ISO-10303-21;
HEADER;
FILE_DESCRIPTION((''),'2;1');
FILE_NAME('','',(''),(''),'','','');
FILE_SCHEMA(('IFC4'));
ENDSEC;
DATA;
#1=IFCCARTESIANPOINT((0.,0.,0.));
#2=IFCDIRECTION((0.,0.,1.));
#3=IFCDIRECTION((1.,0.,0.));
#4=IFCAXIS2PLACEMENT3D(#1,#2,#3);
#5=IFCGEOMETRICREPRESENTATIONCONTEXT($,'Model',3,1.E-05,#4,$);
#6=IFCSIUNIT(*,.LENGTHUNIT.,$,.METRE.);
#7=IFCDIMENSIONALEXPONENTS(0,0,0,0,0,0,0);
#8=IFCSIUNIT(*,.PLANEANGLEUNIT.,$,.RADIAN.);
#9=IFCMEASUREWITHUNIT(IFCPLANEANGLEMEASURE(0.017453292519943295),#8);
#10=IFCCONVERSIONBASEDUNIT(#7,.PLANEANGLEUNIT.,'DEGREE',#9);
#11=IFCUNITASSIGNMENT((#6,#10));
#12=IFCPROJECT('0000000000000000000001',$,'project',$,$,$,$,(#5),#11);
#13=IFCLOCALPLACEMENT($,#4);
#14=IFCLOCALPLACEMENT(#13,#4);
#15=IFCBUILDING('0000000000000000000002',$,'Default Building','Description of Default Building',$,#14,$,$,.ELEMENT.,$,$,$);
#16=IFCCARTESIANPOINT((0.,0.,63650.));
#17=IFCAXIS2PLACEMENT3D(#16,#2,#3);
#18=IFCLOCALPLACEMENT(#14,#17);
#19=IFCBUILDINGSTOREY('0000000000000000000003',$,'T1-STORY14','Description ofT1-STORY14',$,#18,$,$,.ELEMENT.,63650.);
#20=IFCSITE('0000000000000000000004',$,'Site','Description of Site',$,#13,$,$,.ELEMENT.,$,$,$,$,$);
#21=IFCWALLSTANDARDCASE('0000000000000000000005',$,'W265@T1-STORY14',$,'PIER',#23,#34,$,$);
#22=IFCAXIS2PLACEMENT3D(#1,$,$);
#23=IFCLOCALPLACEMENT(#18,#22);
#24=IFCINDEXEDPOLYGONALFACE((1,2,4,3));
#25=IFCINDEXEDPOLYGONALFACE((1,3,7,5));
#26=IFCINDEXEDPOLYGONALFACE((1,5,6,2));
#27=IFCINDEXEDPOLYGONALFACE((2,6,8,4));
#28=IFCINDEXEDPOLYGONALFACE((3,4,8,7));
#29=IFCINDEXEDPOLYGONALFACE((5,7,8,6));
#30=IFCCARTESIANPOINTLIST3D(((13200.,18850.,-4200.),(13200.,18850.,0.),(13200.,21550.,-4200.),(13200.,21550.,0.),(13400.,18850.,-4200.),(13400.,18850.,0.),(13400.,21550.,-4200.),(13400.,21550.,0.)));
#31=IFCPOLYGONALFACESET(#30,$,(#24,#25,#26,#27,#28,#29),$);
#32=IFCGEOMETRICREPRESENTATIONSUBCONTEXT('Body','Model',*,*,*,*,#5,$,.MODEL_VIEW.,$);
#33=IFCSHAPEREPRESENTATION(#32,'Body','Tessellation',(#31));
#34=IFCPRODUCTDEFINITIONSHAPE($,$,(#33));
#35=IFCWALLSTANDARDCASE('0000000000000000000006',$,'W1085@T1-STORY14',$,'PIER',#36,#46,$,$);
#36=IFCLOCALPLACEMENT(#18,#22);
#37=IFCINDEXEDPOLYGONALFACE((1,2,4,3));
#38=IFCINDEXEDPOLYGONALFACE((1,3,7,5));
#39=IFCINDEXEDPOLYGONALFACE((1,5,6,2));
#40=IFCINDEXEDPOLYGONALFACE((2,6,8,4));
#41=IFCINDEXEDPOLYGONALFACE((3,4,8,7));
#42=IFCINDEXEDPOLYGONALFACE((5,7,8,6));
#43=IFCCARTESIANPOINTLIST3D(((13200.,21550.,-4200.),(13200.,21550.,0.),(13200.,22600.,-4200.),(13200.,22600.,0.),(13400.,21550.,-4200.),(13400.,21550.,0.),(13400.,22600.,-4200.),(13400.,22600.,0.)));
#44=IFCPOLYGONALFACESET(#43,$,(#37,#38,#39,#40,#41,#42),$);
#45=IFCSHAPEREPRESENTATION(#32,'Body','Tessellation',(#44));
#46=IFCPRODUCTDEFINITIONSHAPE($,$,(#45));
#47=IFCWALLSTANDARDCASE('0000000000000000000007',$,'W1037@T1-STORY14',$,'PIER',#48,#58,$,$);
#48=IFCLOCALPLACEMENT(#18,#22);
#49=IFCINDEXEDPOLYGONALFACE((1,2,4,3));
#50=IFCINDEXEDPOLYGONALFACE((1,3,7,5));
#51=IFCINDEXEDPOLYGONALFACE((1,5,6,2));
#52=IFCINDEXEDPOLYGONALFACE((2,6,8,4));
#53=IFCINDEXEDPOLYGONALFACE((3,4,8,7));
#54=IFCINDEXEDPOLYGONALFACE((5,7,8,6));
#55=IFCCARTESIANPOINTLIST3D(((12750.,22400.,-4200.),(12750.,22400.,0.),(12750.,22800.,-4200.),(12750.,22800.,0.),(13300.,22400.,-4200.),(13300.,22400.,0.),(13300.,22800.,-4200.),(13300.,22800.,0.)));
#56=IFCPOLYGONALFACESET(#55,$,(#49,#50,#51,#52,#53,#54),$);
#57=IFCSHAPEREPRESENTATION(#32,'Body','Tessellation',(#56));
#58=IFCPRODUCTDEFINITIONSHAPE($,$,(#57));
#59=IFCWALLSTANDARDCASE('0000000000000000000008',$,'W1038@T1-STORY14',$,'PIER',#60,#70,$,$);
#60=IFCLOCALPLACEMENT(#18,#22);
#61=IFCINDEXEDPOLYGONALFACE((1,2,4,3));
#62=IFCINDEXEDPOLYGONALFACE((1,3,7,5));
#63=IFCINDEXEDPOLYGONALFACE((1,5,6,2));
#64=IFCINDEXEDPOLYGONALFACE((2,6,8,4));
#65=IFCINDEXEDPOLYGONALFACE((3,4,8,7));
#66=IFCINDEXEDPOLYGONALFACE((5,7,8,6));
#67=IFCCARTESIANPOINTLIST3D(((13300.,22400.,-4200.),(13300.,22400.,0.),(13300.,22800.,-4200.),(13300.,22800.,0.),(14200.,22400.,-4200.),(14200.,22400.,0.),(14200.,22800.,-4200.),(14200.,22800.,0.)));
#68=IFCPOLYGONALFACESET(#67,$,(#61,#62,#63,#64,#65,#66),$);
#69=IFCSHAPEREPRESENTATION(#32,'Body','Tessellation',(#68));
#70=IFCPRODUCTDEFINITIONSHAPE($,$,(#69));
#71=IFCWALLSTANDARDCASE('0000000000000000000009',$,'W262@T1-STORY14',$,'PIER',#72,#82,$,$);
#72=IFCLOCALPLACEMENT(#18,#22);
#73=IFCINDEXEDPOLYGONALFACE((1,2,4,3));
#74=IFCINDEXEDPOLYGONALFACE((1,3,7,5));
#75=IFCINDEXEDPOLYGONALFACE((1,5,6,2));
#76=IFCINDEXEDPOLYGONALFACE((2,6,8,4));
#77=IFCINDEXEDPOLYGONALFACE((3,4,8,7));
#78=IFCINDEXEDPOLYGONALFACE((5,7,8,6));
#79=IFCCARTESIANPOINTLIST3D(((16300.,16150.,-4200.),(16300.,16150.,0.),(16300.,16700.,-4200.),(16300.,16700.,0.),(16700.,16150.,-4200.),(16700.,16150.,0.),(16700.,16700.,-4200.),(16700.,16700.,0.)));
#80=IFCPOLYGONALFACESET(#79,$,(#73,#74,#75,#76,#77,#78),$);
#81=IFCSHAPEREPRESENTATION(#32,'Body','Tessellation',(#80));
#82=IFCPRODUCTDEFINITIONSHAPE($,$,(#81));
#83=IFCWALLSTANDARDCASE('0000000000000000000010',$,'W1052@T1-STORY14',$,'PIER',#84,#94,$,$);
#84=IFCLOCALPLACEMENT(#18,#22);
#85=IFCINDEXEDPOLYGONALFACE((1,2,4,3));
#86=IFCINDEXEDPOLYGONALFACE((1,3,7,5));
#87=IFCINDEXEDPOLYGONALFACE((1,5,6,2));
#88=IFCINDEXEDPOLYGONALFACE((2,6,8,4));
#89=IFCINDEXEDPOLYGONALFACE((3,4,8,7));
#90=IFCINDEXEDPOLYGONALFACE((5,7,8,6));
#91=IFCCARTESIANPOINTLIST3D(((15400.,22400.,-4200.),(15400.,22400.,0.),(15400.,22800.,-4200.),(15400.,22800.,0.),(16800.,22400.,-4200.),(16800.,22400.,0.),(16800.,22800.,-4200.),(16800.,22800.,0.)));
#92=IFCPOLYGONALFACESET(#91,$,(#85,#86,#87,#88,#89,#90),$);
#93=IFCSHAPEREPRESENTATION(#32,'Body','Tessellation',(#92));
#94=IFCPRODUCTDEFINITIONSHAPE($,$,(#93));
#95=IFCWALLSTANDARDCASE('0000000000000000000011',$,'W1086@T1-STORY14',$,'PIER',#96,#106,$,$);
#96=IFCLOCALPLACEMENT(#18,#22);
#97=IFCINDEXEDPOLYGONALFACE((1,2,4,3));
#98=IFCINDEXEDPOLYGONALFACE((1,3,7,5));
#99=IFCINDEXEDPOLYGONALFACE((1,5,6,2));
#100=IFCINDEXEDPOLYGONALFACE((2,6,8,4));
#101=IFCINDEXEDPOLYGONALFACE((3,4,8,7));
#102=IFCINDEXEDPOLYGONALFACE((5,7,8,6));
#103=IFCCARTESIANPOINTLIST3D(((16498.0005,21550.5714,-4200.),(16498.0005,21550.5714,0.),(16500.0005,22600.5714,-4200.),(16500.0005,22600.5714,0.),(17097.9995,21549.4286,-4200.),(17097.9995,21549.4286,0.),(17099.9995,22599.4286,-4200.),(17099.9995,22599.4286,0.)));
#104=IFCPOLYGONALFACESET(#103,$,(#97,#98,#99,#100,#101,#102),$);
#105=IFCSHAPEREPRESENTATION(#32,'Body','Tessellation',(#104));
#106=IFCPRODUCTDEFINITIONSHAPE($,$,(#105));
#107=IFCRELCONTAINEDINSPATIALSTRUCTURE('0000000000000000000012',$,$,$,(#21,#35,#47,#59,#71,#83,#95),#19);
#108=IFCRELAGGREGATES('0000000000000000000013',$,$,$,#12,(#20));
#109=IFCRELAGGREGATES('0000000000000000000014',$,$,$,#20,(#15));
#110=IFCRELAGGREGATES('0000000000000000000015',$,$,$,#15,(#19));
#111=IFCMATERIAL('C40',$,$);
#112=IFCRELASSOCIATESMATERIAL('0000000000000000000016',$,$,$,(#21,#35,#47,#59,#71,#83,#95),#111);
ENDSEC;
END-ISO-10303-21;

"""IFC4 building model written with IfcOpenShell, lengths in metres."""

from ifc_helpers import new_model, entity, si_unit, converted_unit, frame, origin_with_axes, place, context, subcontext, project, spatial, indexed_curve, outline, extrude, material, element, save


model = new_model("IFC4")

# Units and contexts
model_context = context("Model", 3, precision=1e-05, world=origin_with_axes())
body_context = subcontext(model_context, "Body", "Model", "MODEL_VIEW")
ifc_project = project(units=[si_unit("LENGTHUNIT", "METRE"), converted_unit("PLANEANGLEUNIT", "DEGREE", entity("IfcPlaneAngleMeasure", 0.017453292519943295), si_unit("PLANEANGLEUNIT", "RADIAN"), dimensions=[0, 0, 0, 0, 0, 0, 0])], contexts=[model_context])

# Site, building, storey
site_placement = place(None, origin_with_axes())
site = spatial("IfcSite", under=ifc_project, at=site_placement, Name="Site", Description="Description of Site", CompositionType="ELEMENT")
building_placement = place(site_placement, origin_with_axes())
building = spatial("IfcBuilding", under=site, at=building_placement, Name="Default Building", Description="Description of Default Building", CompositionType="ELEMENT")
storey_placement = place(building_placement, frame((0.0, 0.0, 63650.0), z_axis=(0.0, 0.0, 1.0), x_axis=(1.0, 0.0, 0.0)))
storey = spatial("IfcBuildingStorey", under=building, at=storey_placement, Name="T1-STORY14", Description="Description ofT1-STORY14", CompositionType="ELEMENT", Elevation=63650.0)

# Walls
ifc_material_1 = material(Name="C40")
wall_1_placement = place(storey_placement, frame((13300.0, 18850.0, -4200.0), z_axis=(0.0, 0.0, 1.0), x_axis=(0.0, 1.0, 0.0)))
element("IfcWallStandardCase", 1, at=wall_1_placement, inside=storey, material=ifc_material_1, Name="W265@T1-STORY14", ObjectType="PIER", context=body_context, shape_type="SweptSolid", body=[
    extrude(outline(indexed_curve([(0.0, -100.0), (0.0, 100.0), (2700.0, 100.0), (2700.0, -100.0), (0.0, -100.0)], self_intersect=False)), origin_with_axes(), (0.0, 0.0, 1.0), 4200.0),
])
wall_2_placement = place(storey_placement, frame((13300.0, 21550.0, -4200.0), z_axis=(0.0, 0.0, 1.0), x_axis=(0.0, 1.0, 0.0)))
element("IfcWallStandardCase", 2, at=wall_2_placement, inside=storey, material=ifc_material_1, Name="W1085@T1-STORY14", ObjectType="PIER", context=body_context, shape_type="SweptSolid", body=[
    extrude(outline(indexed_curve([(0.0, -100.0), (0.0, 100.0), (1050.0, 100.0), (1050.0, -100.0), (0.0, -100.0)], self_intersect=False)), origin_with_axes(), (0.0, 0.0, 1.0), 4200.0),
])
wall_3_placement = place(storey_placement, frame((12750.0, 22600.0, -4200.0), z_axis=(0.0, 0.0, 1.0), x_axis=(1.0, 0.0, 0.0)))
element("IfcWallStandardCase", 3, at=wall_3_placement, inside=storey, material=ifc_material_1, Name="W1037@T1-STORY14", ObjectType="PIER", context=body_context, shape_type="SweptSolid", body=[
    extrude(outline(indexed_curve([(0.0, -200.0), (0.0, 200.0), (550.0, 200.0), (550.0, -200.0), (0.0, -200.0)], self_intersect=False)), origin_with_axes(), (0.0, 0.0, 1.0), 4200.0),
])
wall_4_placement = place(storey_placement, frame((13300.0, 22600.0, -4200.0), z_axis=(0.0, 0.0, 1.0), x_axis=(1.0, 0.0, 0.0)))
element("IfcWallStandardCase", 4, at=wall_4_placement, inside=storey, material=ifc_material_1, Name="W1038@T1-STORY14", ObjectType="PIER", context=body_context, shape_type="SweptSolid", body=[
    extrude(outline(indexed_curve([(0.0, -200.0), (0.0, 200.0), (900.0, 200.0), (900.0, -200.0), (0.0, -200.0)], self_intersect=False)), origin_with_axes(), (0.0, 0.0, 1.0), 4200.0),
])
wall_5_placement = place(storey_placement, frame((16500.0, 16150.0, -4200.0), z_axis=(0.0, 0.0, 1.0), x_axis=(0.0, 1.0, 0.0)))
element("IfcWallStandardCase", 5, at=wall_5_placement, inside=storey, material=ifc_material_1, Name="W262@T1-STORY14", ObjectType="PIER", context=body_context, shape_type="SweptSolid", body=[
    extrude(outline(indexed_curve([(0.0, -200.0), (0.0, 200.0), (550.0, 200.0), (550.0, -200.0), (0.0, -200.0)], self_intersect=False)), origin_with_axes(), (0.0, 0.0, 1.0), 4200.0),
])
wall_6_placement = place(storey_placement, frame((15400.0, 22600.0, -4200.0), z_axis=(0.0, 0.0, 1.0), x_axis=(1.0, 0.0, 0.0)))
element("IfcWallStandardCase", 6, at=wall_6_placement, inside=storey, material=ifc_material_1, Name="W1052@T1-STORY14", ObjectType="PIER", context=body_context, shape_type="SweptSolid", body=[
    extrude(outline(indexed_curve([(0.0, -200.0), (0.0, 200.0), (1400.0, 200.0), (1400.0, -200.0), (0.0, -200.0)], self_intersect=False)), origin_with_axes(), (0.0, 0.0, 1.0), 4200.0),
])
wall_7_placement = place(storey_placement, frame((16798.0, 21550.0, -4200.0), z_axis=(0.0, 0.0, 1.0), x_axis=(0.001905, 0.999998, 0.0)))
element("IfcWallStandardCase", 7, at=wall_7_placement, inside=storey, material=ifc_material_1, Name="W1086@T1-STORY14", ObjectType="PIER", context=body_context, shape_type="SweptSolid", body=[
    extrude(outline(indexed_curve([(0.0, -300.0), (0.0, 300.0), (1050.0019, 300.0), (1050.0019, -300.0), (0.0, -300.0)], self_intersect=False)), origin_with_axes(), (0.0, 0.0, 1.0), 4200.0),
])

save(model, "model.ifc")
